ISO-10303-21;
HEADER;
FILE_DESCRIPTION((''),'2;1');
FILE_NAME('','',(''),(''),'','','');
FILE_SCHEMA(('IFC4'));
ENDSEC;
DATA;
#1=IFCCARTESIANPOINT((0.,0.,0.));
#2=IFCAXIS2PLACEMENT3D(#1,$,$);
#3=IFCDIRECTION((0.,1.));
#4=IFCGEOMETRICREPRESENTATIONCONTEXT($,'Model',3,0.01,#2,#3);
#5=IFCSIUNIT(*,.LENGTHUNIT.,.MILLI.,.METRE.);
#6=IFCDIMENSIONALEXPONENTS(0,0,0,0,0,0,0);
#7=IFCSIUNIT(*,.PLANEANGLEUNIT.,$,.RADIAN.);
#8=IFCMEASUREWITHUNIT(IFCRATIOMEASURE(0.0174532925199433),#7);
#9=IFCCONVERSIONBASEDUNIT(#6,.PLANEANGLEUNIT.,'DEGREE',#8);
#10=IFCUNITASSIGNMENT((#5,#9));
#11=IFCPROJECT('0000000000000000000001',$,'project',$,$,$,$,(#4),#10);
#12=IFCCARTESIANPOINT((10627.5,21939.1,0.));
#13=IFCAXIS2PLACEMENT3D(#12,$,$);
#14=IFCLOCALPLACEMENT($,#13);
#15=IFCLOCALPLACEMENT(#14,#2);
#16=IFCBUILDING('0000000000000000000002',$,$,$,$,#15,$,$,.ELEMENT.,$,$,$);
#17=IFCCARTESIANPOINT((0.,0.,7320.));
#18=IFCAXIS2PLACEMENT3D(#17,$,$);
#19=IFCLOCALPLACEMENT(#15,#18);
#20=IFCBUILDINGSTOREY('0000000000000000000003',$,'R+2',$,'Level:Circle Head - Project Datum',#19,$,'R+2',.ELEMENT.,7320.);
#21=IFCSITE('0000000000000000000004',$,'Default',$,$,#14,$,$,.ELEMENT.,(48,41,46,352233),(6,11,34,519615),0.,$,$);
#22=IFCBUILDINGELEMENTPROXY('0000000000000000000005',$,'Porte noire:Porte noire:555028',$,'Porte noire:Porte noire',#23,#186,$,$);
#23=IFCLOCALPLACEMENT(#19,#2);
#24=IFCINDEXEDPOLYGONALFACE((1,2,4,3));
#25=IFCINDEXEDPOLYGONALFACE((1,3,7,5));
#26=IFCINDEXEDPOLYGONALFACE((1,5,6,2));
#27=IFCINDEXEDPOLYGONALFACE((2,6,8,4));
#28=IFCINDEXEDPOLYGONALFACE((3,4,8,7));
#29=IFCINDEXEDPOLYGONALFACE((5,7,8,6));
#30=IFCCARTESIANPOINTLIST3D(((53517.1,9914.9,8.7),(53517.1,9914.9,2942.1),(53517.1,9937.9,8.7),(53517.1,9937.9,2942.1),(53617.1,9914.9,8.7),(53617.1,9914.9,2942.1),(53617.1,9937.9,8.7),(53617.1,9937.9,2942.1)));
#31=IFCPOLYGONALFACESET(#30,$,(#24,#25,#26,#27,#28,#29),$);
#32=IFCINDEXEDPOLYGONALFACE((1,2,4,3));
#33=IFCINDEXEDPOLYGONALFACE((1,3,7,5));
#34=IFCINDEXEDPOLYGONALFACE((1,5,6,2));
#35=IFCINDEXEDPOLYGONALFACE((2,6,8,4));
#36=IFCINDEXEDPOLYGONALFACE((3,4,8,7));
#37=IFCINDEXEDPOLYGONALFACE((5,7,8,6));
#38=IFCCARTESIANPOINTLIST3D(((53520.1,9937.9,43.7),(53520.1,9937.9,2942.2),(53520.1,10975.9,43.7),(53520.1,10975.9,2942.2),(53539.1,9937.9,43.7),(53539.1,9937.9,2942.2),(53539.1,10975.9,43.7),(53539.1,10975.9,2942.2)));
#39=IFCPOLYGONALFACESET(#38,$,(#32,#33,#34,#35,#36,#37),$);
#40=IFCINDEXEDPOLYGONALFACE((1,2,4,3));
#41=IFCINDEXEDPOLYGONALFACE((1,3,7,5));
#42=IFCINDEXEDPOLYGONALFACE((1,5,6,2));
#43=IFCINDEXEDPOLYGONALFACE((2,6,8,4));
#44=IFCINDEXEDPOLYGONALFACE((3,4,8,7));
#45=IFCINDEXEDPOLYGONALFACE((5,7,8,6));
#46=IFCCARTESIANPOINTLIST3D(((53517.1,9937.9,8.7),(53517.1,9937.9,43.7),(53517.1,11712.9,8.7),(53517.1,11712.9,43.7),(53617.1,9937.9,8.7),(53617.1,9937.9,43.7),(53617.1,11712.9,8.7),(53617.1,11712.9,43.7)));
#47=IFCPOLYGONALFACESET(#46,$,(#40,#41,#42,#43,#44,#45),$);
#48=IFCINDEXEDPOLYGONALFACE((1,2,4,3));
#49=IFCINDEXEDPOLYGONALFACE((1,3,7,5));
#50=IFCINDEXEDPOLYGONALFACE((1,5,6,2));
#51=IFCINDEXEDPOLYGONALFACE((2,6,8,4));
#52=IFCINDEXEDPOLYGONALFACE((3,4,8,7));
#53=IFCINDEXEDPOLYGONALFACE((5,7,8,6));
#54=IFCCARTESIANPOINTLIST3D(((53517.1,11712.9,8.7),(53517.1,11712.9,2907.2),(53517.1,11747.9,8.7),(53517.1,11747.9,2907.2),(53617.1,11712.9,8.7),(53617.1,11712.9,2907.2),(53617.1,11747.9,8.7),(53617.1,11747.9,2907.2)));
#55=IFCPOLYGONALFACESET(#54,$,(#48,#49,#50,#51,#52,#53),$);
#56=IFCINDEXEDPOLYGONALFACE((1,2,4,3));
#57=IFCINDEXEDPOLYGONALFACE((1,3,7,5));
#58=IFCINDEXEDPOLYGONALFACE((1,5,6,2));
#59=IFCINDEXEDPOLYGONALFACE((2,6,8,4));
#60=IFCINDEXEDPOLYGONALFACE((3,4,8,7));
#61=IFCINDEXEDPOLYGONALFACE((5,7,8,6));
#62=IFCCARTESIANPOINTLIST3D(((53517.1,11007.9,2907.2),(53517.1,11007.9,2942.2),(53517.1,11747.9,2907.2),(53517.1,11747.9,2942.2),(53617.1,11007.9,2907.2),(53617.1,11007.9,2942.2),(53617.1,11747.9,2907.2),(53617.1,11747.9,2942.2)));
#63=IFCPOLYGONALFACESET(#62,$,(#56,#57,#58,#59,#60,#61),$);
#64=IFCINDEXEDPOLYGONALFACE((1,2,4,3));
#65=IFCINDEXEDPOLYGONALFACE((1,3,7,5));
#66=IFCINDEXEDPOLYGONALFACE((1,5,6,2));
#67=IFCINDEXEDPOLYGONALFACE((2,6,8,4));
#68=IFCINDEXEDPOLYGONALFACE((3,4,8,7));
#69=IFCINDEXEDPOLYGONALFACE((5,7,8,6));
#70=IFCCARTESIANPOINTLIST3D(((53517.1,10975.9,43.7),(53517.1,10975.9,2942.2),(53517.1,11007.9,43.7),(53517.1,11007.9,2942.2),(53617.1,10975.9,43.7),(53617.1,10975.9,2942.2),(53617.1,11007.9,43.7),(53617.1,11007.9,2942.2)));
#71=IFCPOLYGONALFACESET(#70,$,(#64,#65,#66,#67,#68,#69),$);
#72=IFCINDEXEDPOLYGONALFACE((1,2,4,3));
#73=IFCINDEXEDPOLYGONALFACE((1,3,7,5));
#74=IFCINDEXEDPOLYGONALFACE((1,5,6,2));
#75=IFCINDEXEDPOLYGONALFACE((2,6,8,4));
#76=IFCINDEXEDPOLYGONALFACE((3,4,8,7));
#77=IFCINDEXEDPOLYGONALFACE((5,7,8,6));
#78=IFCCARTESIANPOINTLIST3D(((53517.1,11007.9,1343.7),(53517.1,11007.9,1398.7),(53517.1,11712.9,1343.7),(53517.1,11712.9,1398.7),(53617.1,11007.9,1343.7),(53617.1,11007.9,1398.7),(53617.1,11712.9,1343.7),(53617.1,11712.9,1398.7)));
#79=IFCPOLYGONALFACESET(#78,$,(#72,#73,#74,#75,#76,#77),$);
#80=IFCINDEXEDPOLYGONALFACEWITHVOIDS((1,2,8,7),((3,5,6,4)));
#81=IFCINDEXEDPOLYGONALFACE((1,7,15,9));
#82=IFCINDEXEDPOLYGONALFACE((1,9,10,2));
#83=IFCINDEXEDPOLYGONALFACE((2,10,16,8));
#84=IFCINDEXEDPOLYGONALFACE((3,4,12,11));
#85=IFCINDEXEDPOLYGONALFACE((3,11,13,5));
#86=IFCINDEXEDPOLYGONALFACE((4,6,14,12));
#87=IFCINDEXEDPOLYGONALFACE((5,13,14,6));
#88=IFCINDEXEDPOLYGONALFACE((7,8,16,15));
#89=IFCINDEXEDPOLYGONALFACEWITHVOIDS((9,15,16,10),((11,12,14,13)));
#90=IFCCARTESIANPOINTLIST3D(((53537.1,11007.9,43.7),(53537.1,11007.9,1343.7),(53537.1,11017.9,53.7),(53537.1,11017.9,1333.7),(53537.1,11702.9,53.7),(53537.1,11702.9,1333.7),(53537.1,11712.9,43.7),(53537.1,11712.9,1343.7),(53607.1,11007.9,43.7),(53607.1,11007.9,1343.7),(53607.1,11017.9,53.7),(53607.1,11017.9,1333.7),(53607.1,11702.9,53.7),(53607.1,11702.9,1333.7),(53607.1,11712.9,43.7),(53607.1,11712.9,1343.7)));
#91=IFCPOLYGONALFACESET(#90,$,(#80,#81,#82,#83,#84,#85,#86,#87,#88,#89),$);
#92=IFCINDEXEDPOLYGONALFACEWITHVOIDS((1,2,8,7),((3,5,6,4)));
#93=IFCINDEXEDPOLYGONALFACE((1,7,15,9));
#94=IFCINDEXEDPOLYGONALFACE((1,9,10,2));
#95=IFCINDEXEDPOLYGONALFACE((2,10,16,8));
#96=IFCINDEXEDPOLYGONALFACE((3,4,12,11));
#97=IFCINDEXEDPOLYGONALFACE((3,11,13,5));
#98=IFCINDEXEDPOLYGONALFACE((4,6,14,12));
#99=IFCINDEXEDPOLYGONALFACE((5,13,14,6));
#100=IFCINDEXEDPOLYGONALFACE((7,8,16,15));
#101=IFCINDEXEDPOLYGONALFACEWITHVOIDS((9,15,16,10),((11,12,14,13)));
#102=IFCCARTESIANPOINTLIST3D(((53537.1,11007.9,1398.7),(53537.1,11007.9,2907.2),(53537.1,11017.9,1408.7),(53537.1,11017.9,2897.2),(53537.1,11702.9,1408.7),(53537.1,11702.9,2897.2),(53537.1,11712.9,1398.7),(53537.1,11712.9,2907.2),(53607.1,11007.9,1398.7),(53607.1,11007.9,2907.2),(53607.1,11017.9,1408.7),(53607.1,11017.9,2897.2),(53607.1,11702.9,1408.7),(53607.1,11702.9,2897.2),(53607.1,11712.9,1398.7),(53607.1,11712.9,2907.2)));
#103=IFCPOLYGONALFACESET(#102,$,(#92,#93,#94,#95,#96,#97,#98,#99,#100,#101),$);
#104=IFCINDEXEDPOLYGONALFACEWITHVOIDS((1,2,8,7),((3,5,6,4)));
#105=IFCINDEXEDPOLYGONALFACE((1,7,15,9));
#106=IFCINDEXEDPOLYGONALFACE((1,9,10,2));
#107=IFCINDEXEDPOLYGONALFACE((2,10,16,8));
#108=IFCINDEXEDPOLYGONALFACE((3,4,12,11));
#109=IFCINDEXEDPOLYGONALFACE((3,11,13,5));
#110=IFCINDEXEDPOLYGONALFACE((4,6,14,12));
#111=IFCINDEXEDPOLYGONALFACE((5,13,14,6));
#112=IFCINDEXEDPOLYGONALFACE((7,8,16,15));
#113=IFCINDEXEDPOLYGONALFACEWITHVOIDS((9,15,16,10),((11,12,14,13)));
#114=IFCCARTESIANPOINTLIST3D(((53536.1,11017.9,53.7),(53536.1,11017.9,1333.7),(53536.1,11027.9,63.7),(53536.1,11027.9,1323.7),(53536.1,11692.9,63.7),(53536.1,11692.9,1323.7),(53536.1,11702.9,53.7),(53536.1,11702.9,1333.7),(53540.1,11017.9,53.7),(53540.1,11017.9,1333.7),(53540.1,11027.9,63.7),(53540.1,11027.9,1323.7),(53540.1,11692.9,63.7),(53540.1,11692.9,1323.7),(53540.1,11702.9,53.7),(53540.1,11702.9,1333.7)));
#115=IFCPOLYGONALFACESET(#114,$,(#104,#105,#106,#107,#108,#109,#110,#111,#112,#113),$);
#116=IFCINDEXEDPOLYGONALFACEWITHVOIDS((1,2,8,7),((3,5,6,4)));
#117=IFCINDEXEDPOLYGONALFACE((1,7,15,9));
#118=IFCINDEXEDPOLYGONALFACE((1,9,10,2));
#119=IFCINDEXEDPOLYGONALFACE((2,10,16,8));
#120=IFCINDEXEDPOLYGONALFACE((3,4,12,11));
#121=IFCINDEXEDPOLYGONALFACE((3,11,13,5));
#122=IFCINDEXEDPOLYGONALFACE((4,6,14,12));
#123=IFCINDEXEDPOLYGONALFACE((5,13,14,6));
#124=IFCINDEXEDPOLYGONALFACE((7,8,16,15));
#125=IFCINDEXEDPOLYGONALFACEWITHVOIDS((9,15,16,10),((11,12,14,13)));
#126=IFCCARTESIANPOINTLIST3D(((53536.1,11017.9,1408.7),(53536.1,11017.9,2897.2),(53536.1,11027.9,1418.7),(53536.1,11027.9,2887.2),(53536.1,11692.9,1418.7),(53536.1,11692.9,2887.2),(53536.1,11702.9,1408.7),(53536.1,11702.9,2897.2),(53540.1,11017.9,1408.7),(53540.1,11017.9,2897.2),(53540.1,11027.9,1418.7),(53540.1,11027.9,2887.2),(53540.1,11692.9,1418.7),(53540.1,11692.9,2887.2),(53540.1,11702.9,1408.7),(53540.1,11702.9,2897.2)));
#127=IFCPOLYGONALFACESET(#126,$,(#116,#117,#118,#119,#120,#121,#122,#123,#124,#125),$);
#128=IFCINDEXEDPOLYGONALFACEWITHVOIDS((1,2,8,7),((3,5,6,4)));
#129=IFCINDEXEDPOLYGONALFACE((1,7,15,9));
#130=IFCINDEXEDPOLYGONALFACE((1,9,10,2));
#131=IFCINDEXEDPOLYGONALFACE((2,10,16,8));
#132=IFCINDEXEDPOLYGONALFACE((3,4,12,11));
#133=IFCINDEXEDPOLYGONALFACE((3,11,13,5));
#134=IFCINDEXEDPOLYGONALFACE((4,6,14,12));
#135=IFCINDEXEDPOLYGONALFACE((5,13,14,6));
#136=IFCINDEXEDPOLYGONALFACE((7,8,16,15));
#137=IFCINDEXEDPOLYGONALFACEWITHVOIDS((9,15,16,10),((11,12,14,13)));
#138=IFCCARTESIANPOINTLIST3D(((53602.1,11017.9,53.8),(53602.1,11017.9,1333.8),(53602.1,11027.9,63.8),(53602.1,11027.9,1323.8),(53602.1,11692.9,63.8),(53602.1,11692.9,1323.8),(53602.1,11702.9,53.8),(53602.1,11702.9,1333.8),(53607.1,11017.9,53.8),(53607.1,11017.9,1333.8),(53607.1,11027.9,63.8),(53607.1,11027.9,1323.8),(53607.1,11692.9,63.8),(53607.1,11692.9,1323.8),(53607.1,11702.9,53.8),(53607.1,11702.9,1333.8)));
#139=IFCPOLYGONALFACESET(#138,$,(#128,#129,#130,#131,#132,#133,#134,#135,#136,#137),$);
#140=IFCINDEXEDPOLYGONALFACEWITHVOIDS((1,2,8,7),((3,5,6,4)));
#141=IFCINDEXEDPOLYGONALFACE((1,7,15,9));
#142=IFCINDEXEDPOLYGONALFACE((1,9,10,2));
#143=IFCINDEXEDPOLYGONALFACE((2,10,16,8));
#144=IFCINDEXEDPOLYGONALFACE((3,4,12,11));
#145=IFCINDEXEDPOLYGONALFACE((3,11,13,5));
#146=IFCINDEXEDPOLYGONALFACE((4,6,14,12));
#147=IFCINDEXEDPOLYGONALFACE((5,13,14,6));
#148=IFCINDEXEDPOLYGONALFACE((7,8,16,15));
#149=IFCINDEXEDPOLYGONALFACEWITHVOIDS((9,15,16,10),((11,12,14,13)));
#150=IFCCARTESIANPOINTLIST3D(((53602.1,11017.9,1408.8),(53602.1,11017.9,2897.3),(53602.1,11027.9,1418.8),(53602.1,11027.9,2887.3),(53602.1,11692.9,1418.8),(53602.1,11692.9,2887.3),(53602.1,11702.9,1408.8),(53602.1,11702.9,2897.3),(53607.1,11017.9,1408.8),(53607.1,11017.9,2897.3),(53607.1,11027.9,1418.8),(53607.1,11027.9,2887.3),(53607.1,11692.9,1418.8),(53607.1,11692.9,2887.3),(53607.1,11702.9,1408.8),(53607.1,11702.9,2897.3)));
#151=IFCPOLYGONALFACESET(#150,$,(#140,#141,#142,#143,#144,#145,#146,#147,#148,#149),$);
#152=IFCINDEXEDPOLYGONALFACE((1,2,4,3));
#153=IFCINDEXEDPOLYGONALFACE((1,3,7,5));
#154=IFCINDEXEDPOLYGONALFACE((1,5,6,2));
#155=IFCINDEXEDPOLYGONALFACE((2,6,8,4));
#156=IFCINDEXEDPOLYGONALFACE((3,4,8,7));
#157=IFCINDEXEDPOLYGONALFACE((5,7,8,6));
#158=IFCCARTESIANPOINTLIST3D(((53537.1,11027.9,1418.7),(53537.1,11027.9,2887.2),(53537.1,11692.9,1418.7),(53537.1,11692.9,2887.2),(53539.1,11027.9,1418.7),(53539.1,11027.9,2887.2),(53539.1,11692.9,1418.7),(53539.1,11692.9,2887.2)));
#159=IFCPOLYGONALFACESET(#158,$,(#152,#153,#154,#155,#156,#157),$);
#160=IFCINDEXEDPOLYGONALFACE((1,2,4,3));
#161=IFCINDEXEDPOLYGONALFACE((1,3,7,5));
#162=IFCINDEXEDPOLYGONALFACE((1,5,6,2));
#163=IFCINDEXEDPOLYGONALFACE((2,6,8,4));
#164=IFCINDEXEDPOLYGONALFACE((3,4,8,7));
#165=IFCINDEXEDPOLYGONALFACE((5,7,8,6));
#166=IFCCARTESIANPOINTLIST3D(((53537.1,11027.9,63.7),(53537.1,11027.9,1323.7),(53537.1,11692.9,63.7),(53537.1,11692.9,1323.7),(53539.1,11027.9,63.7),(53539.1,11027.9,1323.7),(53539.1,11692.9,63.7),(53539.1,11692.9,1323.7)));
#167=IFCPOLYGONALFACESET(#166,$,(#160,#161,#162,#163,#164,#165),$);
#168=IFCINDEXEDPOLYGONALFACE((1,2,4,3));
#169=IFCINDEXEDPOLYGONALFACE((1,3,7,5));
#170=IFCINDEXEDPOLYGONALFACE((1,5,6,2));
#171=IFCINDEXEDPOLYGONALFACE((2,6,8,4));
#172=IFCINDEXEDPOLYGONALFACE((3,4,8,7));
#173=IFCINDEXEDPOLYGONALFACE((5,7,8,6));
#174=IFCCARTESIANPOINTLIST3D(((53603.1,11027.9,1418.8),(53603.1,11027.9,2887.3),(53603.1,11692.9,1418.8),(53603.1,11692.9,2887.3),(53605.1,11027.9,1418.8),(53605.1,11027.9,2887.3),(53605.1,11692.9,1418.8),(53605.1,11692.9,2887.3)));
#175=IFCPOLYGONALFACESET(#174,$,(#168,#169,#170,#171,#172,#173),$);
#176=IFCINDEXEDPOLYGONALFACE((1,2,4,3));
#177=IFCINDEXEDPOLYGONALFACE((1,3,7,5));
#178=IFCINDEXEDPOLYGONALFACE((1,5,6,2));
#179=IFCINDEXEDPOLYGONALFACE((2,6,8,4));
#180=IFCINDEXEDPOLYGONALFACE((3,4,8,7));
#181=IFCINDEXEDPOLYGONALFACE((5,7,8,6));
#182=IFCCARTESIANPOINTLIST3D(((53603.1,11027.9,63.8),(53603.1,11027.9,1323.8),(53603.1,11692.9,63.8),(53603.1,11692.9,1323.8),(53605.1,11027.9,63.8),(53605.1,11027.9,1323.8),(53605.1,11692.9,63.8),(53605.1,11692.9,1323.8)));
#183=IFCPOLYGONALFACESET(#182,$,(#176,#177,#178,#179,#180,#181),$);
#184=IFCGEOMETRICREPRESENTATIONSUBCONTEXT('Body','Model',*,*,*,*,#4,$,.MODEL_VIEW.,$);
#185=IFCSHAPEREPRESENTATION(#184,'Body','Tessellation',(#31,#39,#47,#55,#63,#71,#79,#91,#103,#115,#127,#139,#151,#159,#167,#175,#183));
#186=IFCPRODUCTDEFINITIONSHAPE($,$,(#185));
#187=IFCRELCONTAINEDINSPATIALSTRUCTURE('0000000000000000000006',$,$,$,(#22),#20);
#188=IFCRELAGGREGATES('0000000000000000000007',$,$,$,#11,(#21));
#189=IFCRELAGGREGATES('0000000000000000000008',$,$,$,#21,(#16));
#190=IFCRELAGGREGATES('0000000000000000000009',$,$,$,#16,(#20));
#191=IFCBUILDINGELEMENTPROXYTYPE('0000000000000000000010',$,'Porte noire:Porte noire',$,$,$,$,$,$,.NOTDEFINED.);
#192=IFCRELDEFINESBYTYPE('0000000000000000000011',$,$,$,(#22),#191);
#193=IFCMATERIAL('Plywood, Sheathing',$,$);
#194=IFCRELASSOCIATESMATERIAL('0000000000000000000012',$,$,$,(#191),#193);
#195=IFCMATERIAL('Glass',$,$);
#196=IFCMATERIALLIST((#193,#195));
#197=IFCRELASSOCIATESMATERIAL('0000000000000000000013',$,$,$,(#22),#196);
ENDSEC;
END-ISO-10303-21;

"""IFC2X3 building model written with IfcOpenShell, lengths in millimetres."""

from ifc_helpers import new_model, entity, si_unit, converted_unit, direction, frame, frame_2d, origin, origin_2d_with_axis, place, context, subcontext, project, spatial, polyline, rectangle, outline, extrude, source, transform, mapped, material, material_list, type_object, type_shapes, element, save


model = new_model("IFC2X3")

# Units and contexts
model_context = context("Model", 3, precision=0.01, world=origin(), true_north=direction((0.0, 1.0)))
body_context = subcontext(model_context, "Body", "Model", "MODEL_VIEW")
ifc_project = project(units=[si_unit("LENGTHUNIT", "METRE", prefix="MILLI"), converted_unit("PLANEANGLEUNIT", "DEGREE", entity("IfcRatioMeasure", 0.0174532925199433), si_unit("PLANEANGLEUNIT", "RADIAN"), dimensions=[0, 0, 0, 0, 0, 0, 0])], contexts=[model_context])

# Site, building, storey
site_placement = place(None, frame((10627.5, 21939.1, 0.0)))
site = spatial("IfcSite", under=ifc_project, at=site_placement, Name="Default", CompositionType="ELEMENT", RefLatitude=(48, 41, 46, 352233), RefLongitude=(6, 11, 34, 519615), RefElevation=0.0)
building_placement = place(site_placement, origin())
building = spatial("IfcBuilding", under=site, at=building_placement, CompositionType="ELEMENT")
storey_placement = place(building_placement, frame((0.0, 0.0, 7320.0)))
storey = spatial("IfcBuildingStorey", under=building, at=storey_placement, Name="R+2", ObjectType="Level:Circle Head - Project Datum", LongName="R+2", CompositionType="ELEMENT", Elevation=7320.0)

# Building element proxy
ifc_material_1 = material(Name="Glass")
ifc_material_2 = material(Name="Plywood, Sheathing")
building_element_proxy_type_1 = type_object("IfcBuildingElementProxyType", Name="Porte noire:Porte noire", PredefinedType="NOTDEFINED", material=ifc_material_2)
shared_shape_1 = source(origin(), body_context, "Body", "SweptSolid", [
    extrude(rectangle(XDim=23.0, YDim=100.0, at=frame_2d((0.0, 0.0), x_axis=(1.0, 0.0))), frame((-950.9, 50.0, 8.7), z_axis=(0.0, 0.0, 1.0), x_axis=(-1.0, 0.0, 0.0)), (0.0, 0.0, 1.0), 2933.3),
    extrude(rectangle(XDim=1038.0, YDim=19.0, at=frame_2d((0.0, 0.0), x_axis=(1.0, 0.0))), frame((-420.4, 87.5, 43.7), z_axis=(0.0, 0.0, 1.0), x_axis=(-1.0, 0.0, 0.0)), (0.0, 0.0, 1.0), 2898.5),
    extrude(rectangle(XDim=1775.0, YDim=100.0, at=origin_2d_with_axis()), frame((-51.9, 50.0, 8.7), z_axis=(0.0, 0.0, 1.0), x_axis=(-1.0, 0.0, 0.0)), (0.0, 0.0, 1.0), 35.0),
    extrude(rectangle(XDim=35.0, YDim=100.0, at=origin_2d_with_axis()), frame((853.1, 50.0, 8.7), z_axis=(0.0, 0.0, 1.0), x_axis=(-1.0, 0.0, 0.0)), (0.0, 0.0, 1.0), 2898.5),
    extrude(rectangle(XDim=740.0, YDim=100.0, at=origin_2d_with_axis()), frame((500.6, 50.0, 2907.2), z_axis=(0.0, 0.0, 1.0), x_axis=(-1.0, 0.0, 0.0)), (0.0, 0.0, 1.0), 35.0),
    extrude(rectangle(XDim=32.0, YDim=100.0, at=origin_2d_with_axis()), frame((114.6, 50.0, 43.7), z_axis=(0.0, 0.0, 1.0), x_axis=(-1.0, 0.0, 0.0)), (0.0, 0.0, 1.0), 2898.5),
    extrude(rectangle(XDim=705.0, YDim=100.0, at=origin_2d_with_axis()), frame((483.1, 50.0, 1343.7), z_axis=(0.0, 0.0, 1.0), x_axis=(-1.0, 0.0, 0.0)), (0.0, 0.0, 1.0), 55.0),
    extrude(outline(polyline([(-352.5, -650.0), (352.5, -650.0), (352.5, 650.0), (-352.5, 650.0), (-352.5, -650.0)]), holes=[polyline([(342.5, 640.0), (342.5, -640.0), (-342.5, -640.0), (-342.5, 640.0), (342.5, 640.0)])]), frame((483.1, 10.0, 693.7), z_axis=(0.0, 1.0, 0.0), x_axis=(1.0, 0.0, 0.0)), (0.0, 0.0, 1.0), 70.0),
    extrude(outline(polyline([(-754.2, -352.5), (754.2, -352.5), (754.2, 352.5), (-754.2, 352.5), (-754.2, -352.5)]), holes=[polyline([(744.2, 342.5), (744.2, -342.5), (-744.2, -342.5), (-744.2, 342.5), (744.2, 342.5)])]), frame((483.1, 10.0, 2153.0), z_axis=(0.0, 1.0, 0.0), x_axis=(0.0, 0.0, 1.0)), (0.0, 0.0, 1.0), 70.0),
    extrude(outline(polyline([(-640.0, -342.5), (640.0, -342.5), (640.0, 342.5), (-640.0, 342.5), (-640.0, -342.5)]), holes=[polyline([(630.0, 332.5), (630.0, -332.5), (-630.0, -332.5), (-630.0, 332.5), (630.0, 332.5)])]), frame((483.1, 77.0, 693.7), z_axis=(0.0, 1.0, 0.0), x_axis=(0.0, 0.0, 1.0)), (0.0, 0.0, 1.0), 4.0),
    extrude(outline(polyline([(-744.2, -342.5), (744.2, -342.5), (744.2, 342.5), (-744.2, 342.5), (-744.2, -342.5)]), holes=[polyline([(734.2, 332.5), (734.2, -332.5), (-734.2, -332.5), (-734.2, 332.5), (734.2, 332.5)])]), frame((483.1, 77.0, 2153.0), z_axis=(0.0, 1.0, 0.0), x_axis=(0.0, 0.0, 1.0)), (0.0, 0.0, 1.0), 4.0),
    extrude(outline(polyline([(-640.0, -342.5), (640.0, -342.5), (640.0, 342.5), (-640.0, 342.5), (-640.0, -342.5)]), holes=[polyline([(630.0, 332.5), (630.0, -332.5), (-630.0, -332.5), (-630.0, 332.5), (630.0, 332.5)])]), frame((483.1, 10.0, 693.8), z_axis=(0.0, 1.0, 0.0), x_axis=(0.0, 0.0, 1.0)), (0.0, 0.0, 1.0), 5.0),
    extrude(outline(polyline([(-744.2, -342.5), (744.2, -342.5), (744.2, 342.5), (-744.2, 342.5), (-744.2, -342.5)]), holes=[polyline([(734.2, 332.5), (734.2, -332.5), (-734.2, -332.5), (-734.2, 332.5), (734.2, 332.5)])]), frame((483.1, 10.0, 2153.0), z_axis=(0.0, 1.0, 0.0), x_axis=(0.0, 0.0, 1.0)), (0.0, 0.0, 1.0), 5.0),
    extrude(rectangle(XDim=665.0, YDim=2.0, at=frame_2d((0.0, 0.0), x_axis=(1.0, 0.0))), frame((483.1, 79.0, 1418.7), z_axis=(0.0, 0.0, 1.0), x_axis=(-1.0, 0.0, 0.0)), (0.0, 0.0, 1.0), 1468.5),
    extrude(rectangle(XDim=665.0, YDim=2.0, at=frame_2d((0.0, 0.0), x_axis=(1.0, 0.0))), frame((483.1, 79.0, 63.7), z_axis=(0.0, 0.0, 1.0), x_axis=(-1.0, 0.0, 0.0)), (0.0, 0.0, 1.0), 1260.0),
    extrude(rectangle(XDim=665.0, YDim=2.0, at=frame_2d((0.0, 0.0), x_axis=(1.0, 0.0))), frame((483.1, 13.0, 1418.8), z_axis=(0.0, 0.0, 1.0), x_axis=(-1.0, 0.0, 0.0)), (0.0, 0.0, 1.0), 1468.5),
    extrude(rectangle(XDim=665.0, YDim=2.0, at=frame_2d((0.0, 0.0), x_axis=(1.0, 0.0))), frame((483.1, 13.0, 63.8), z_axis=(0.0, 0.0, 1.0), x_axis=(-1.0, 0.0, 0.0)), (0.0, 0.0, 1.0), 1260.0),
])
type_shapes(building_element_proxy_type_1, [shared_shape_1])
ifc_material_list_1 = material_list([ifc_material_2, ifc_material_1])
proxy_1_placement = place(storey_placement, frame((53617.1, 10877.3, 0.0), z_axis=(0.0, 0.0, 1.0), x_axis=(0.0, 1.0, 0.0)))
element("IfcBuildingElementProxy", 1, at=proxy_1_placement, inside=storey, type_object=building_element_proxy_type_1, material=ifc_material_list_1, Name="Porte noire:Porte noire:555028", ObjectType="Porte noire:Porte noire", context=body_context, shape_type="MappedRepresentation", body=[
    mapped(shared_shape_1, transform((0.0, 0.0, 0.0), scale=1.0)),
])

save(model, "model.ifc")
